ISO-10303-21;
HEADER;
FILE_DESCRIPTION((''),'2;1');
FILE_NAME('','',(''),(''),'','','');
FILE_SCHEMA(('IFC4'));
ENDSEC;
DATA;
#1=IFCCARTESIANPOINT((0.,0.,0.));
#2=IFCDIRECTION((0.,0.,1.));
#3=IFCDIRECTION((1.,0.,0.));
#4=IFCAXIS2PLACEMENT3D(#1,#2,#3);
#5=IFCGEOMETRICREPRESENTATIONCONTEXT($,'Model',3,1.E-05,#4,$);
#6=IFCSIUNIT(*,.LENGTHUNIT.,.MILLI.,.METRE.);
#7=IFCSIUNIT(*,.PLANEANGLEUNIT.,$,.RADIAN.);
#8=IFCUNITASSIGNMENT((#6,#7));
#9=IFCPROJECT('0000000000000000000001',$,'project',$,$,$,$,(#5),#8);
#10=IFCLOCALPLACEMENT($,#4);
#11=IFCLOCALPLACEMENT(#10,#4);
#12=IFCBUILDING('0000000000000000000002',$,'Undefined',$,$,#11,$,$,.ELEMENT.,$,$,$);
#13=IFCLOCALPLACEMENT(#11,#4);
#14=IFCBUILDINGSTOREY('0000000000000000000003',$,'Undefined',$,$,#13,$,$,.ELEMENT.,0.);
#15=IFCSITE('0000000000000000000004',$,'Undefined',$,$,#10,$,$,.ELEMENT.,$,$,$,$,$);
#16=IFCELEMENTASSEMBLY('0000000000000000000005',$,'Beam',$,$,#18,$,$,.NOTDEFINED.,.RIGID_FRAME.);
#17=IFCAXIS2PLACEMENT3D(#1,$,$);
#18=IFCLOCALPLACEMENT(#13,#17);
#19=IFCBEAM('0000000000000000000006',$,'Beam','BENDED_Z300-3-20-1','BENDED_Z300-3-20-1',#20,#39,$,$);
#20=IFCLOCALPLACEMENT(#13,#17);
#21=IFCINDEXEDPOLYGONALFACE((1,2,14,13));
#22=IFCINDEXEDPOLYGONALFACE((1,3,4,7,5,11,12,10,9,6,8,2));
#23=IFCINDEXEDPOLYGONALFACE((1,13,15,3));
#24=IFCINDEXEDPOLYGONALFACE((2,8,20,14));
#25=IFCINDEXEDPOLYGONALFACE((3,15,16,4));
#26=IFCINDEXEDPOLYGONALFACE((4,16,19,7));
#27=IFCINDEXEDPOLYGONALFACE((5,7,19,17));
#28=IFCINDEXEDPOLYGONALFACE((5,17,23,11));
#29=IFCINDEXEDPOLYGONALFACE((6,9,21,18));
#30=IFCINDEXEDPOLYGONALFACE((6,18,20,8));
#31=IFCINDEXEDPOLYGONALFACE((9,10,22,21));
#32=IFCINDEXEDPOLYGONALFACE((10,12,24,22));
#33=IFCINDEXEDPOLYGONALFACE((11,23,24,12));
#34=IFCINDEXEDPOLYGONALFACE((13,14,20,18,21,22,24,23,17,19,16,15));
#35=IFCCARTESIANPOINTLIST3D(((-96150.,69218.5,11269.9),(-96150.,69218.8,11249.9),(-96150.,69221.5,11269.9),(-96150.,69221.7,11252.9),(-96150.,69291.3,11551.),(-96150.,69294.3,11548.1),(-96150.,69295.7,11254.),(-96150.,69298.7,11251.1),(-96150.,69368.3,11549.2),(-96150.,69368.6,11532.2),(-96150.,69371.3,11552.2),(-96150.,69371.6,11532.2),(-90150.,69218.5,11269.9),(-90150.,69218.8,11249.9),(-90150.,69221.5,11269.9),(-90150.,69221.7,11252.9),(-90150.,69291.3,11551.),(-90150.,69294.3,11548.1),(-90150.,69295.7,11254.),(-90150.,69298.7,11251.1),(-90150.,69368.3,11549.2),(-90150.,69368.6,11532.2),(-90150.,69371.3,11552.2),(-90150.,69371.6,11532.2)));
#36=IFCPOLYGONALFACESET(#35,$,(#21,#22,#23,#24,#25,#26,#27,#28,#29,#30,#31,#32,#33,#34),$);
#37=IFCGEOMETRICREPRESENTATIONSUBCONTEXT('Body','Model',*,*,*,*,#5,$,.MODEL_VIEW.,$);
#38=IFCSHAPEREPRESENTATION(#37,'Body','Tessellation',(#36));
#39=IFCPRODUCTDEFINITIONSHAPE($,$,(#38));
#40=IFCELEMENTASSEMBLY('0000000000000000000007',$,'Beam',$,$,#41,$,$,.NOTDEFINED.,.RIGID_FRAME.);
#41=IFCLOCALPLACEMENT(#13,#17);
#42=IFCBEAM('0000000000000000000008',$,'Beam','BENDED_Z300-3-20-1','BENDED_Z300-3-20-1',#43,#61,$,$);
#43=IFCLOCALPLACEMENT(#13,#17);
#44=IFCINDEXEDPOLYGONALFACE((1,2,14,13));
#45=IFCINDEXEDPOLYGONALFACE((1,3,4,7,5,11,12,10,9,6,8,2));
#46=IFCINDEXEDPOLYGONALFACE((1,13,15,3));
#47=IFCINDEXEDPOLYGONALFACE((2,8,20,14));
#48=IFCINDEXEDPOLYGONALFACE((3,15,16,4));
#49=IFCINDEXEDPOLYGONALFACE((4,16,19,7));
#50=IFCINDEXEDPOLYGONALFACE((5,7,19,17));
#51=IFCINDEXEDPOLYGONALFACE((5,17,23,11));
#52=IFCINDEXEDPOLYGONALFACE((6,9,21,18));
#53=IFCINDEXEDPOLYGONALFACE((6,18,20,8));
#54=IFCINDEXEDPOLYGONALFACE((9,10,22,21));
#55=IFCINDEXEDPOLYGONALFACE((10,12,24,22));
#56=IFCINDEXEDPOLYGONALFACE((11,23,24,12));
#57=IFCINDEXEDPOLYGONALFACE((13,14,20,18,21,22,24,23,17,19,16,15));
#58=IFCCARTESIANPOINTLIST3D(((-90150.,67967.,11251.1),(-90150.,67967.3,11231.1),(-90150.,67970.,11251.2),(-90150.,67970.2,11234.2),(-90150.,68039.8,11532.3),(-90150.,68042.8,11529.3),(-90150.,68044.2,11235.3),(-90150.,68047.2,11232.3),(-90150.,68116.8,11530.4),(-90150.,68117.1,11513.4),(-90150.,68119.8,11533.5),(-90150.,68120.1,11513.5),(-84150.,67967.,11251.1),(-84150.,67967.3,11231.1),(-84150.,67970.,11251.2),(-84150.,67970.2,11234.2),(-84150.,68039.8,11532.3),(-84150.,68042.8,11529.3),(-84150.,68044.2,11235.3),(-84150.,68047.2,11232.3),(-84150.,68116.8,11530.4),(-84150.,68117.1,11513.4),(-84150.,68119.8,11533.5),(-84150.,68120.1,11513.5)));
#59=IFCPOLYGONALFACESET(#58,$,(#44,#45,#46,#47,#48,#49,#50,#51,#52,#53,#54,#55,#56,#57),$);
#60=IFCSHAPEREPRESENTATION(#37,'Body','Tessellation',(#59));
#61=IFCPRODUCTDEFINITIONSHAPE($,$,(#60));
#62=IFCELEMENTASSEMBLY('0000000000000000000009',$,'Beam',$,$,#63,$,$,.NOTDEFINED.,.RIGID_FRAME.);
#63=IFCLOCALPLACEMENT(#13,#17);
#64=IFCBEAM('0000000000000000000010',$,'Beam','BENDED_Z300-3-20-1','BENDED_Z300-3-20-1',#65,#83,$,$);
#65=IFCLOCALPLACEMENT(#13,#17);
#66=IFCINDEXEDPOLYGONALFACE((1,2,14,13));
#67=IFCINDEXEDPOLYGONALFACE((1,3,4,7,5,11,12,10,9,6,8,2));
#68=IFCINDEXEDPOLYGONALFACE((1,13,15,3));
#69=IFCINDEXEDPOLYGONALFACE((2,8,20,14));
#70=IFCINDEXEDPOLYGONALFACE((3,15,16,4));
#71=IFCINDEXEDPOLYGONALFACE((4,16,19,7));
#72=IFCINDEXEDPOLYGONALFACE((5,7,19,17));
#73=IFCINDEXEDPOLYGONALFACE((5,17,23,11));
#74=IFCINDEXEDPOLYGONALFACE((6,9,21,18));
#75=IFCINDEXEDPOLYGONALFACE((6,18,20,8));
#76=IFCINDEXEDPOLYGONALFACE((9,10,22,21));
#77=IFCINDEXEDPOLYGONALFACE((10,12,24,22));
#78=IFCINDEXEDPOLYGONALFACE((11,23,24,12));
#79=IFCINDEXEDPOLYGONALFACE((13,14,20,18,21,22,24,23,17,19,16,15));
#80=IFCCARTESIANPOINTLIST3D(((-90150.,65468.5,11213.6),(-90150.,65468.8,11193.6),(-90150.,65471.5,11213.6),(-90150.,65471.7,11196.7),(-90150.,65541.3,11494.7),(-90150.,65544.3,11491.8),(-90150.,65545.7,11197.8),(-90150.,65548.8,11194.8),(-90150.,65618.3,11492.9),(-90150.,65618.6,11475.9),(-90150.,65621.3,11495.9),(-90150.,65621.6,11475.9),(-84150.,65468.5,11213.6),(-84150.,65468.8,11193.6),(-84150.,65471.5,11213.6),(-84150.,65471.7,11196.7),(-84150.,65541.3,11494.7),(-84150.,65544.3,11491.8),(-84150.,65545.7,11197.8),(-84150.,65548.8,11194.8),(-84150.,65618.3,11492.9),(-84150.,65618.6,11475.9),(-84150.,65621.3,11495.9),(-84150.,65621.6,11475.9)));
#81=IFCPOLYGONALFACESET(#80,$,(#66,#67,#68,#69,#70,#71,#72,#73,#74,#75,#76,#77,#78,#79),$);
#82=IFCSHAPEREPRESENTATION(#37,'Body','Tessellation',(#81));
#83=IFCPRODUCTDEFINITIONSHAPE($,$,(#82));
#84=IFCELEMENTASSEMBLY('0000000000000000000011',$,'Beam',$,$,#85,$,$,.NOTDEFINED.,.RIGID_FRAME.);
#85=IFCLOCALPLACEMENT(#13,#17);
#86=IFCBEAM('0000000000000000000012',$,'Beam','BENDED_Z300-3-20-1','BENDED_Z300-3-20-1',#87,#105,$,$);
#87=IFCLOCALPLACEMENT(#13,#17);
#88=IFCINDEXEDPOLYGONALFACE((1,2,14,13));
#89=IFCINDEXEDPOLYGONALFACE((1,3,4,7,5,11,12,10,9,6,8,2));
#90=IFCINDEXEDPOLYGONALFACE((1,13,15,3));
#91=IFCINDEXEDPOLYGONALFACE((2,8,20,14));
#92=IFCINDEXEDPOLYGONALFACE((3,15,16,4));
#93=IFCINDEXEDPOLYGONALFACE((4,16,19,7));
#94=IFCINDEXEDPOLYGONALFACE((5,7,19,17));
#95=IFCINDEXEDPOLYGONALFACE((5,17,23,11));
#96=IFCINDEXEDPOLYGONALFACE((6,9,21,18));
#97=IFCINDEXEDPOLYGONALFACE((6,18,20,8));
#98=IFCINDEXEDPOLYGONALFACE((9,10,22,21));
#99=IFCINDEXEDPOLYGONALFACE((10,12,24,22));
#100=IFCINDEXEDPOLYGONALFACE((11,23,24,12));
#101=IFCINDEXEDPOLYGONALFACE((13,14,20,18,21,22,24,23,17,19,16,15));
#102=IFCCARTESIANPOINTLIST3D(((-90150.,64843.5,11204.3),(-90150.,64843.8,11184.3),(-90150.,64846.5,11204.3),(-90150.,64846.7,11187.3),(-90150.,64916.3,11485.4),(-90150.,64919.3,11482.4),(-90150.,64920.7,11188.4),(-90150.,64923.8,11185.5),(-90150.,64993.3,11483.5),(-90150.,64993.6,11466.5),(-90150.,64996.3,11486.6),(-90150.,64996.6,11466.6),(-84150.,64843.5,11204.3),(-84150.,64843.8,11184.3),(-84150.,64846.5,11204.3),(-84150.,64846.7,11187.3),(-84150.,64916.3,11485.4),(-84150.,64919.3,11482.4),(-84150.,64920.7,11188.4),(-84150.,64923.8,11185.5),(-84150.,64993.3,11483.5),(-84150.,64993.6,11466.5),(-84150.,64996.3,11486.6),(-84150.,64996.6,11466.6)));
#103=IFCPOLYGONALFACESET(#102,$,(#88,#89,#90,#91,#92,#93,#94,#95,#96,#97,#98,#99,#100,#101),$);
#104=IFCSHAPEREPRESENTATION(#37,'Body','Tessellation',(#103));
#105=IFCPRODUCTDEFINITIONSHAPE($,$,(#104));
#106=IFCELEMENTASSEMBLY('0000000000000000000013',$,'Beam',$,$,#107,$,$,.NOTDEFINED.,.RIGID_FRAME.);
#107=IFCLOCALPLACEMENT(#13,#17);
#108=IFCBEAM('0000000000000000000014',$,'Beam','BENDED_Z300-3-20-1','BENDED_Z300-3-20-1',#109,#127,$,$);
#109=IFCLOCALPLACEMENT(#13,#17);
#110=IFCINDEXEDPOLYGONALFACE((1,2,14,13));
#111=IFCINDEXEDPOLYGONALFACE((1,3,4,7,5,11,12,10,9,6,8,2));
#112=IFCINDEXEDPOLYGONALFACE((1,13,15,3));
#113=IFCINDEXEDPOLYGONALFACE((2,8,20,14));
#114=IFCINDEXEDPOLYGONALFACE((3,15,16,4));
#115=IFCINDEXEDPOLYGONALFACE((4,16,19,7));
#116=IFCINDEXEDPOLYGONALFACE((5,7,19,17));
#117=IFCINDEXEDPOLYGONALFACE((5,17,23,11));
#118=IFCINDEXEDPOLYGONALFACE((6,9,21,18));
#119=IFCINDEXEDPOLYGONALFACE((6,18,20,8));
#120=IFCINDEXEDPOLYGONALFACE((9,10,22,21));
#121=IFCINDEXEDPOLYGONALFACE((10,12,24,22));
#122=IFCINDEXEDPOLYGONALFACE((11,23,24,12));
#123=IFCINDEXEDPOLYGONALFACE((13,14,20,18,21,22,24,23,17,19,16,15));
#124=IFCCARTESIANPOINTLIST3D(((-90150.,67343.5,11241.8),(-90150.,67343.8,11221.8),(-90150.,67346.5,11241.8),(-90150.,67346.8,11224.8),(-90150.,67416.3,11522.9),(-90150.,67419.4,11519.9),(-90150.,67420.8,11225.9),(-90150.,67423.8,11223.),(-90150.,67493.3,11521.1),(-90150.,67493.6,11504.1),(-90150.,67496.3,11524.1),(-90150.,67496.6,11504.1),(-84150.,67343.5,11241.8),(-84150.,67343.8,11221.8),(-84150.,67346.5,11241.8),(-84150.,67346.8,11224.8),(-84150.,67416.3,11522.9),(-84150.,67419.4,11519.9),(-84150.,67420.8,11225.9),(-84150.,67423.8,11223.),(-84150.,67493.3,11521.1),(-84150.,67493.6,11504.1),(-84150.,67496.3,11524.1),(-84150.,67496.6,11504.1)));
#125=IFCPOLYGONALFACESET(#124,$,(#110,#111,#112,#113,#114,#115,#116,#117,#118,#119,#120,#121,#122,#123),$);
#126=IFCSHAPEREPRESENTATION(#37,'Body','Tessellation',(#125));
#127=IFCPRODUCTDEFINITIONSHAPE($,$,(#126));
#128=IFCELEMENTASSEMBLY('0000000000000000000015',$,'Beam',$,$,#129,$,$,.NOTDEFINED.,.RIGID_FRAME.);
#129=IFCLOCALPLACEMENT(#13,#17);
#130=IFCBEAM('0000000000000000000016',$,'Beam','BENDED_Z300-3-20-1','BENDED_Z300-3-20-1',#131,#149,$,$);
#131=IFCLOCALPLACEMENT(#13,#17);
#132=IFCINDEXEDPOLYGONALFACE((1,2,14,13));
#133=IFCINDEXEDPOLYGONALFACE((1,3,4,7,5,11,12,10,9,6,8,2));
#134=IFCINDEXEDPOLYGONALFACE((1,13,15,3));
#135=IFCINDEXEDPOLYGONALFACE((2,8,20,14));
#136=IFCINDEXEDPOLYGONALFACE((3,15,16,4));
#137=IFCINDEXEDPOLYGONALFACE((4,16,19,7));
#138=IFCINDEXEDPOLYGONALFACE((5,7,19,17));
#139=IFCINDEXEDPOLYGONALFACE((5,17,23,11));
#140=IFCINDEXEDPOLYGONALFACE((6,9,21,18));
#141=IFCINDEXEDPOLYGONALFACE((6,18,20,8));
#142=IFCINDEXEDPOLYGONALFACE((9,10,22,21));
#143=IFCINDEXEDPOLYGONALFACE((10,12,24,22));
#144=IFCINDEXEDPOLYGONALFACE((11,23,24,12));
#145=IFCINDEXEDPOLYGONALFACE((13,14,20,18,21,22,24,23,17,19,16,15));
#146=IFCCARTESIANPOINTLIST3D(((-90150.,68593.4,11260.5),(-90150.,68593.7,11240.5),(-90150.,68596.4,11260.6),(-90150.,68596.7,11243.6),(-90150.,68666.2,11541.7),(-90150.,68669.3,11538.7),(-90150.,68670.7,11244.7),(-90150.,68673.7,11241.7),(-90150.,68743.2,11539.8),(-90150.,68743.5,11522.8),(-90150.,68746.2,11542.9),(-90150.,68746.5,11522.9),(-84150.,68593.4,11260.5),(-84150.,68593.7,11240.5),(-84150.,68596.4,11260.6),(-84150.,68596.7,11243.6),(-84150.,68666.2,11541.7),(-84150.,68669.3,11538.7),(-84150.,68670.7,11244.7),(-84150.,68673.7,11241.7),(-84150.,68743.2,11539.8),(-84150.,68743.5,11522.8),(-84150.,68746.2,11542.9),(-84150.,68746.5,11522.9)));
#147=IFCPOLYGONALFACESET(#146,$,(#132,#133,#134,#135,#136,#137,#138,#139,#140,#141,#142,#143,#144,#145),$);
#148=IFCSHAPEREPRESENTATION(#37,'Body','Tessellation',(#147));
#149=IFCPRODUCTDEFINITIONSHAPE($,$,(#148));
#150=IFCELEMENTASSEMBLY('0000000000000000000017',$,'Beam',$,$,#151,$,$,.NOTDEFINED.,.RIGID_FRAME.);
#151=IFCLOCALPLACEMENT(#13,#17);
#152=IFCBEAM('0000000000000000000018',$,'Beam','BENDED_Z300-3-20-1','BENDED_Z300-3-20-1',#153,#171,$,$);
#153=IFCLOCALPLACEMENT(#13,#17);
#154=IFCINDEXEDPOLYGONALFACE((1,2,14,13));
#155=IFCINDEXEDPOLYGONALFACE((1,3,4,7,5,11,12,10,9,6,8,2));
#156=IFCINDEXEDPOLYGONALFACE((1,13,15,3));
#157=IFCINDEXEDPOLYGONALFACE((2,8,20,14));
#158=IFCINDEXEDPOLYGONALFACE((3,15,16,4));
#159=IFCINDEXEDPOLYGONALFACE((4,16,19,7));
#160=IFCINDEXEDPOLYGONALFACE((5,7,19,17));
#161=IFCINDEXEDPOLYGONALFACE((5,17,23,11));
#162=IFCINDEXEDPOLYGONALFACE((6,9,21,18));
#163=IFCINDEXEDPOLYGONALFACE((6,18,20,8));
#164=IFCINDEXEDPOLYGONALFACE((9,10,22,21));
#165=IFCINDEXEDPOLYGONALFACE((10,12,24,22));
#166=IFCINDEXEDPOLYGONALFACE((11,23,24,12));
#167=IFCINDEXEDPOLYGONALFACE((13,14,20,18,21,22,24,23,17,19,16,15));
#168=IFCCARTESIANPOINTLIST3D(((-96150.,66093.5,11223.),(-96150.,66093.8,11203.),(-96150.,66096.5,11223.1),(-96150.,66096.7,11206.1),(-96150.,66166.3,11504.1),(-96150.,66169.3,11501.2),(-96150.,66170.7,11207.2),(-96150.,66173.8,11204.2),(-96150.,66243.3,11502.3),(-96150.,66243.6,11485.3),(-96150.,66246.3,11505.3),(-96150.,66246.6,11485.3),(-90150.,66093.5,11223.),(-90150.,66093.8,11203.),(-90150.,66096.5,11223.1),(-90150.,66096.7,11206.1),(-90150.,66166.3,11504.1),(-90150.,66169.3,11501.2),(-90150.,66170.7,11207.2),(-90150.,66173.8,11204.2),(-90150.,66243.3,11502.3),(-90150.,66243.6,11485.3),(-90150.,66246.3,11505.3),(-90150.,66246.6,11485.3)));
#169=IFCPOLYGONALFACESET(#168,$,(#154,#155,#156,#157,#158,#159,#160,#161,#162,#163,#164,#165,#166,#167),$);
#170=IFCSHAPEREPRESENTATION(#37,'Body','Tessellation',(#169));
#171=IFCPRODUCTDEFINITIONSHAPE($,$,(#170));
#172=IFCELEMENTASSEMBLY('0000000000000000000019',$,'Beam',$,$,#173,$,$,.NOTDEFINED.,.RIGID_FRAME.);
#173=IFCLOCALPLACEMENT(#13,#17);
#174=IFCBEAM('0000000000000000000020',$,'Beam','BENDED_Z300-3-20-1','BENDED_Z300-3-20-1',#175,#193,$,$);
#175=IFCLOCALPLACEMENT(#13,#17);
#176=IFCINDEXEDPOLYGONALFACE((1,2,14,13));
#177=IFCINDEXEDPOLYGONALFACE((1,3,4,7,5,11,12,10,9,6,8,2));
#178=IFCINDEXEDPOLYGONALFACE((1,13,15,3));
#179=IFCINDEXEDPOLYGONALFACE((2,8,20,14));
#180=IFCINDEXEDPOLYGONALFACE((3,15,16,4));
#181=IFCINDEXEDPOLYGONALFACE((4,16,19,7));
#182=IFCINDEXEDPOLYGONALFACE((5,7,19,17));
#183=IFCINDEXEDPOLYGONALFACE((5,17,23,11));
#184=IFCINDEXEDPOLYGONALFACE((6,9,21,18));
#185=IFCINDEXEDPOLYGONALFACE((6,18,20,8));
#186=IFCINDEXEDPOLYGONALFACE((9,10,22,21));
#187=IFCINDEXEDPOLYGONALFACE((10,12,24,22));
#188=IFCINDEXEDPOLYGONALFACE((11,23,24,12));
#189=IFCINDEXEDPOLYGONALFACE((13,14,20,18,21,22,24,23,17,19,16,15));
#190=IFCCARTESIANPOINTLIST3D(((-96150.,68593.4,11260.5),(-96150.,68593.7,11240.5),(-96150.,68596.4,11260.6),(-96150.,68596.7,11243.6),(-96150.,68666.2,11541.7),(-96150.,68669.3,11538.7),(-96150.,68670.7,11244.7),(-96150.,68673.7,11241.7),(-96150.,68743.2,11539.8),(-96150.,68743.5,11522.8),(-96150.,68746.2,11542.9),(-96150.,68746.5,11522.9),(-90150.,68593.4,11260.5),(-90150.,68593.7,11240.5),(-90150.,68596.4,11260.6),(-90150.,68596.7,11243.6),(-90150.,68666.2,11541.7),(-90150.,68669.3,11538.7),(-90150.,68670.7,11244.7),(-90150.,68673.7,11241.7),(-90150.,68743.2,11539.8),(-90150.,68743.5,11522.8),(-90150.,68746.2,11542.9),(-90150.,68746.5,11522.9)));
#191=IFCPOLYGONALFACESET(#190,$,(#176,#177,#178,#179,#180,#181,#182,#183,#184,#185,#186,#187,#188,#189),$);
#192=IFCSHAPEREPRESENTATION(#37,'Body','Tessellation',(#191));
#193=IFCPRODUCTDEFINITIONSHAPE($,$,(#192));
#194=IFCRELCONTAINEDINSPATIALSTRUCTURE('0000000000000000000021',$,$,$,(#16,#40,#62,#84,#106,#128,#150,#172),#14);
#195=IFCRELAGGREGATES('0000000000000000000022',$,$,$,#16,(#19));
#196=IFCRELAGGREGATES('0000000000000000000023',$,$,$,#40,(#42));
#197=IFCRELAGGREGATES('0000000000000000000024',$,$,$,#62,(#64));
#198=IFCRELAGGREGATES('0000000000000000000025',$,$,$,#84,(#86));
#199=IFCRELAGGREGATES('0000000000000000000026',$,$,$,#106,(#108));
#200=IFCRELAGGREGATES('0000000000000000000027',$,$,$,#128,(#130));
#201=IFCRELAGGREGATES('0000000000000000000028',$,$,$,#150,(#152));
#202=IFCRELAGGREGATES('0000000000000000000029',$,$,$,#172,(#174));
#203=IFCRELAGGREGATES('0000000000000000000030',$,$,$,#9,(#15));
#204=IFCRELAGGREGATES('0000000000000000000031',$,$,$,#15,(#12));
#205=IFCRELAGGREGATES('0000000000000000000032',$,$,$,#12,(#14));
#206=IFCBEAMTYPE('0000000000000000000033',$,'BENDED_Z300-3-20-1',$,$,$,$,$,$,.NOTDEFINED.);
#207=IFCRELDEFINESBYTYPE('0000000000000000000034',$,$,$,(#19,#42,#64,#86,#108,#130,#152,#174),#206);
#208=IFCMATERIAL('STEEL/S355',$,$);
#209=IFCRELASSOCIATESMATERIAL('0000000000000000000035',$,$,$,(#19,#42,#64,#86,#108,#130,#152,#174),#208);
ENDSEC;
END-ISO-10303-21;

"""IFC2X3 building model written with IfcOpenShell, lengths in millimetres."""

from ifc_helpers import new_model, si_unit, frame, origin_with_axes, place, context, subcontext, project, spatial, polyline, outline, extrude, material, type_object, element, aggregate, save


model = new_model("IFC2X3")

# Units and contexts
model_context = context("Model", 3, precision=1e-05, world=origin_with_axes())
body_context = subcontext(model_context, "Body", "Model", "MODEL_VIEW")
ifc_project = project(units=[si_unit("LENGTHUNIT", "METRE", prefix="MILLI"), si_unit("PLANEANGLEUNIT", "RADIAN")], contexts=[model_context])

# Site, building, storey
site_placement = place(None, origin_with_axes())
site = spatial("IfcSite", under=ifc_project, at=site_placement, Name="Undefined", CompositionType="ELEMENT")
building_placement = place(site_placement, origin_with_axes())
building = spatial("IfcBuilding", under=site, at=building_placement, Name="Undefined", CompositionType="ELEMENT")
storey_placement = place(building_placement, origin_with_axes())
storey = spatial("IfcBuildingStorey", under=building, at=storey_placement, Name="Undefined", CompositionType="ELEMENT", Elevation=0.0)

# Element assemblies, beams
assembly_1_placement = place(storey_placement, origin_with_axes())
assembly_1 = element("IfcElementAssembly", 1, at=assembly_1_placement, inside=storey, Name="Beam", AssemblyPlace="NOTDEFINED", PredefinedType="RIGID_FRAME")
ifc_material = material(Name="STEEL/S355")
beam_type_1 = type_object("IfcBeamType", Name="BENDED_Z300-3-20-1", PredefinedType="NOTDEFINED")
beam_1_placement = place(assembly_1_placement, frame((-90150.0, 69295.0, 11401.1), z_axis=(0.0, -0.014963, 0.999888), x_axis=(-1.0, 0.0, 0.0)))
beam_1 = element("IfcBeam", 2, at=beam_1_placement, type_object=beam_type_1, material=ifc_material, Name="Beam", Description="BENDED_Z300-3-20-1", ObjectType="BENDED_Z300-3-20-1", context=body_context, shape_type="SweptSolid", body=[
    extrude(outline(polyline([(1.5, -150.0), (-78.5, -150.0), (-78.5, -130.0), (-75.5, -130.0), (-75.5, -147.0), (-1.5, -147.0), (-1.5, 150.0), (78.5, 150.0), (78.5, 130.0), (75.5, 130.0), (75.5, 147.0), (1.5, 147.0), (1.5, -150.0)])), frame((6000.0, 0.0, 0.0), z_axis=(-1.0, 0.0, 0.0), x_axis=(0.0, -1.0, 0.0)), (0.0, 0.0, 1.0), 6000.0),
])
aggregate(assembly_1, [beam_1])
assembly_2_placement = place(storey_placement, origin_with_axes())
assembly_2 = element("IfcElementAssembly", 3, at=assembly_2_placement, inside=storey, Name="Beam", AssemblyPlace="NOTDEFINED", PredefinedType="RIGID_FRAME")
beam_2_placement = place(assembly_2_placement, frame((-84150.0, 68043.5, 11382.3), z_axis=(0.0, -0.014963, 0.999888), x_axis=(-1.0, 0.0, 0.0)))
beam_2 = element("IfcBeam", 4, at=beam_2_placement, type_object=beam_type_1, material=ifc_material, Name="Beam", Description="BENDED_Z300-3-20-1", ObjectType="BENDED_Z300-3-20-1", context=body_context, shape_type="SweptSolid", body=[
    extrude(outline(polyline([(1.5, -150.0), (-78.5, -150.0), (-78.5, -130.0), (-75.5, -130.0), (-75.5, -147.0), (-1.5, -147.0), (-1.5, 150.0), (78.5, 150.0), (78.5, 130.0), (75.5, 130.0), (75.5, 147.0), (1.5, 147.0), (1.5, -150.0)])), frame((6000.0, 0.0, 0.0), z_axis=(-1.0, 0.0, 0.0), x_axis=(0.0, -1.0, 0.0)), (0.0, 0.0, 1.0), 6000.0),
])
aggregate(assembly_2, [beam_2])
assembly_3_placement = place(storey_placement, origin_with_axes())
assembly_3 = element("IfcElementAssembly", 5, at=assembly_3_placement, inside=storey, Name="Beam", AssemblyPlace="NOTDEFINED", PredefinedType="RIGID_FRAME")
beam_3_placement = place(assembly_3_placement, frame((-84150.0, 65545.0, 11344.8), z_axis=(0.0, -0.014963, 0.999888), x_axis=(-1.0, 0.0, 0.0)))
beam_3 = element("IfcBeam", 6, at=beam_3_placement, type_object=beam_type_1, material=ifc_material, Name="Beam", Description="BENDED_Z300-3-20-1", ObjectType="BENDED_Z300-3-20-1", context=body_context, shape_type="SweptSolid", body=[
    extrude(outline(polyline([(1.5, -150.0), (-78.5, -150.0), (-78.5, -130.0), (-75.5, -130.0), (-75.5, -147.0), (-1.5, -147.0), (-1.5, 150.0), (78.5, 150.0), (78.5, 130.0), (75.5, 130.0), (75.5, 147.0), (1.5, 147.0), (1.5, -150.0)])), frame((6000.0, 0.0, 0.0), z_axis=(-1.0, 0.0, 0.0), x_axis=(0.0, -1.0, 0.0)), (0.0, 0.0, 1.0), 6000.0),
])
aggregate(assembly_3, [beam_3])
assembly_4_placement = place(storey_placement, origin_with_axes())
assembly_4 = element("IfcElementAssembly", 7, at=assembly_4_placement, inside=storey, Name="Beam", AssemblyPlace="NOTDEFINED", PredefinedType="RIGID_FRAME")
beam_4_placement = place(assembly_4_placement, frame((-84150.0, 64920.0, 11335.4), z_axis=(0.0, -0.014963, 0.999888), x_axis=(-1.0, 0.0, 0.0)))
beam_4 = element("IfcBeam", 8, at=beam_4_placement, type_object=beam_type_1, material=ifc_material, Name="Beam", Description="BENDED_Z300-3-20-1", ObjectType="BENDED_Z300-3-20-1", context=body_context, shape_type="SweptSolid", body=[
    extrude(outline(polyline([(1.5, -150.0), (-78.5, -150.0), (-78.5, -130.0), (-75.5, -130.0), (-75.5, -147.0), (-1.5, -147.0), (-1.5, 150.0), (78.5, 150.0), (78.5, 130.0), (75.5, 130.0), (75.5, 147.0), (1.5, 147.0), (1.5, -150.0)])), frame((6000.0, 0.0, 0.0), z_axis=(-1.0, 0.0, 0.0), x_axis=(0.0, -1.0, 0.0)), (0.0, 0.0, 1.0), 6000.0),
])
aggregate(assembly_4, [beam_4])
assembly_5_placement = place(storey_placement, origin_with_axes())
assembly_5 = element("IfcElementAssembly", 9, at=assembly_5_placement, inside=storey, Name="Beam", AssemblyPlace="NOTDEFINED", PredefinedType="RIGID_FRAME")
beam_5_placement = place(assembly_5_placement, frame((-84150.0, 67420.1, 11372.9), z_axis=(0.0, -0.014963, 0.999888), x_axis=(-1.0, 0.0, 0.0)))
beam_5 = element("IfcBeam", 10, at=beam_5_placement, type_object=beam_type_1, material=ifc_material, Name="Beam", Description="BENDED_Z300-3-20-1", ObjectType="BENDED_Z300-3-20-1", context=body_context, shape_type="SweptSolid", body=[
    extrude(outline(polyline([(1.5, -150.0), (-78.5, -150.0), (-78.5, -130.0), (-75.5, -130.0), (-75.5, -147.0), (-1.5, -147.0), (-1.5, 150.0), (78.5, 150.0), (78.5, 130.0), (75.5, 130.0), (75.5, 147.0), (1.5, 147.0), (1.5, -150.0)])), frame((6000.0, 0.0, 0.0), z_axis=(-1.0, 0.0, 0.0), x_axis=(0.0, -1.0, 0.0)), (0.0, 0.0, 1.0), 6000.0),
])
aggregate(assembly_5, [beam_5])
assembly_6_placement = place(storey_placement, origin_with_axes())
assembly_6 = element("IfcElementAssembly", 11, at=assembly_6_placement, inside=storey, Name="Beam", AssemblyPlace="NOTDEFINED", PredefinedType="RIGID_FRAME")
beam_6_placement = place(assembly_6_placement, frame((-84150.0, 68670.0, 11391.7), z_axis=(0.0, -0.014963, 0.999888), x_axis=(-1.0, 0.0, 0.0)))
beam_6 = element("IfcBeam", 12, at=beam_6_placement, type_object=beam_type_1, material=ifc_material, Name="Beam", Description="BENDED_Z300-3-20-1", ObjectType="BENDED_Z300-3-20-1", context=body_context, shape_type="SweptSolid", body=[
    extrude(outline(polyline([(1.5, -150.0), (-78.5, -150.0), (-78.5, -130.0), (-75.5, -130.0), (-75.5, -147.0), (-1.5, -147.0), (-1.5, 150.0), (78.5, 150.0), (78.5, 130.0), (75.5, 130.0), (75.5, 147.0), (1.5, 147.0), (1.5, -150.0)])), frame((6000.0, 0.0, 0.0), z_axis=(-1.0, 0.0, 0.0), x_axis=(0.0, -1.0, 0.0)), (0.0, 0.0, 1.0), 6000.0),
])
aggregate(assembly_6, [beam_6])
assembly_7_placement = place(storey_placement, origin_with_axes())
assembly_7 = element("IfcElementAssembly", 13, at=assembly_7_placement, inside=storey, Name="Beam", AssemblyPlace="NOTDEFINED", PredefinedType="RIGID_FRAME")
beam_7_placement = place(assembly_7_placement, frame((-90150.0, 66170.0, 11354.2), z_axis=(0.0, -0.014963, 0.999888), x_axis=(-1.0, 0.0, 0.0)))
beam_7 = element("IfcBeam", 14, at=beam_7_placement, type_object=beam_type_1, material=ifc_material, Name="Beam", Description="BENDED_Z300-3-20-1", ObjectType="BENDED_Z300-3-20-1", context=body_context, shape_type="SweptSolid", body=[
    extrude(outline(polyline([(1.5, -150.0), (-78.5, -150.0), (-78.5, -130.0), (-75.5, -130.0), (-75.5, -147.0), (-1.5, -147.0), (-1.5, 150.0), (78.5, 150.0), (78.5, 130.0), (75.5, 130.0), (75.5, 147.0), (1.5, 147.0), (1.5, -150.0)])), frame((6000.0, 0.0, 0.0), z_axis=(-1.0, 0.0, 0.0), x_axis=(0.0, -1.0, 0.0)), (0.0, 0.0, 1.0), 6000.0),
])
aggregate(assembly_7, [beam_7])
assembly_8_placement = place(storey_placement, origin_with_axes())
assembly_8 = element("IfcElementAssembly", 15, at=assembly_8_placement, inside=storey, Name="Beam", AssemblyPlace="NOTDEFINED", PredefinedType="RIGID_FRAME")
beam_8_placement = place(assembly_8_placement, frame((-90150.0, 68670.0, 11391.7), z_axis=(0.0, -0.014963, 0.999888), x_axis=(-1.0, 0.0, 0.0)))
beam_8 = element("IfcBeam", 16, at=beam_8_placement, type_object=beam_type_1, material=ifc_material, Name="Beam", Description="BENDED_Z300-3-20-1", ObjectType="BENDED_Z300-3-20-1", context=body_context, shape_type="SweptSolid", body=[
    extrude(outline(polyline([(1.5, -150.0), (-78.5, -150.0), (-78.5, -130.0), (-75.5, -130.0), (-75.5, -147.0), (-1.5, -147.0), (-1.5, 150.0), (78.5, 150.0), (78.5, 130.0), (75.5, 130.0), (75.5, 147.0), (1.5, 147.0), (1.5, -150.0)])), frame((6000.0, 0.0, 0.0), z_axis=(-1.0, 0.0, 0.0), x_axis=(0.0, -1.0, 0.0)), (0.0, 0.0, 1.0), 6000.0),
])
aggregate(assembly_8, [beam_8])

save(model, "model.ifc")
